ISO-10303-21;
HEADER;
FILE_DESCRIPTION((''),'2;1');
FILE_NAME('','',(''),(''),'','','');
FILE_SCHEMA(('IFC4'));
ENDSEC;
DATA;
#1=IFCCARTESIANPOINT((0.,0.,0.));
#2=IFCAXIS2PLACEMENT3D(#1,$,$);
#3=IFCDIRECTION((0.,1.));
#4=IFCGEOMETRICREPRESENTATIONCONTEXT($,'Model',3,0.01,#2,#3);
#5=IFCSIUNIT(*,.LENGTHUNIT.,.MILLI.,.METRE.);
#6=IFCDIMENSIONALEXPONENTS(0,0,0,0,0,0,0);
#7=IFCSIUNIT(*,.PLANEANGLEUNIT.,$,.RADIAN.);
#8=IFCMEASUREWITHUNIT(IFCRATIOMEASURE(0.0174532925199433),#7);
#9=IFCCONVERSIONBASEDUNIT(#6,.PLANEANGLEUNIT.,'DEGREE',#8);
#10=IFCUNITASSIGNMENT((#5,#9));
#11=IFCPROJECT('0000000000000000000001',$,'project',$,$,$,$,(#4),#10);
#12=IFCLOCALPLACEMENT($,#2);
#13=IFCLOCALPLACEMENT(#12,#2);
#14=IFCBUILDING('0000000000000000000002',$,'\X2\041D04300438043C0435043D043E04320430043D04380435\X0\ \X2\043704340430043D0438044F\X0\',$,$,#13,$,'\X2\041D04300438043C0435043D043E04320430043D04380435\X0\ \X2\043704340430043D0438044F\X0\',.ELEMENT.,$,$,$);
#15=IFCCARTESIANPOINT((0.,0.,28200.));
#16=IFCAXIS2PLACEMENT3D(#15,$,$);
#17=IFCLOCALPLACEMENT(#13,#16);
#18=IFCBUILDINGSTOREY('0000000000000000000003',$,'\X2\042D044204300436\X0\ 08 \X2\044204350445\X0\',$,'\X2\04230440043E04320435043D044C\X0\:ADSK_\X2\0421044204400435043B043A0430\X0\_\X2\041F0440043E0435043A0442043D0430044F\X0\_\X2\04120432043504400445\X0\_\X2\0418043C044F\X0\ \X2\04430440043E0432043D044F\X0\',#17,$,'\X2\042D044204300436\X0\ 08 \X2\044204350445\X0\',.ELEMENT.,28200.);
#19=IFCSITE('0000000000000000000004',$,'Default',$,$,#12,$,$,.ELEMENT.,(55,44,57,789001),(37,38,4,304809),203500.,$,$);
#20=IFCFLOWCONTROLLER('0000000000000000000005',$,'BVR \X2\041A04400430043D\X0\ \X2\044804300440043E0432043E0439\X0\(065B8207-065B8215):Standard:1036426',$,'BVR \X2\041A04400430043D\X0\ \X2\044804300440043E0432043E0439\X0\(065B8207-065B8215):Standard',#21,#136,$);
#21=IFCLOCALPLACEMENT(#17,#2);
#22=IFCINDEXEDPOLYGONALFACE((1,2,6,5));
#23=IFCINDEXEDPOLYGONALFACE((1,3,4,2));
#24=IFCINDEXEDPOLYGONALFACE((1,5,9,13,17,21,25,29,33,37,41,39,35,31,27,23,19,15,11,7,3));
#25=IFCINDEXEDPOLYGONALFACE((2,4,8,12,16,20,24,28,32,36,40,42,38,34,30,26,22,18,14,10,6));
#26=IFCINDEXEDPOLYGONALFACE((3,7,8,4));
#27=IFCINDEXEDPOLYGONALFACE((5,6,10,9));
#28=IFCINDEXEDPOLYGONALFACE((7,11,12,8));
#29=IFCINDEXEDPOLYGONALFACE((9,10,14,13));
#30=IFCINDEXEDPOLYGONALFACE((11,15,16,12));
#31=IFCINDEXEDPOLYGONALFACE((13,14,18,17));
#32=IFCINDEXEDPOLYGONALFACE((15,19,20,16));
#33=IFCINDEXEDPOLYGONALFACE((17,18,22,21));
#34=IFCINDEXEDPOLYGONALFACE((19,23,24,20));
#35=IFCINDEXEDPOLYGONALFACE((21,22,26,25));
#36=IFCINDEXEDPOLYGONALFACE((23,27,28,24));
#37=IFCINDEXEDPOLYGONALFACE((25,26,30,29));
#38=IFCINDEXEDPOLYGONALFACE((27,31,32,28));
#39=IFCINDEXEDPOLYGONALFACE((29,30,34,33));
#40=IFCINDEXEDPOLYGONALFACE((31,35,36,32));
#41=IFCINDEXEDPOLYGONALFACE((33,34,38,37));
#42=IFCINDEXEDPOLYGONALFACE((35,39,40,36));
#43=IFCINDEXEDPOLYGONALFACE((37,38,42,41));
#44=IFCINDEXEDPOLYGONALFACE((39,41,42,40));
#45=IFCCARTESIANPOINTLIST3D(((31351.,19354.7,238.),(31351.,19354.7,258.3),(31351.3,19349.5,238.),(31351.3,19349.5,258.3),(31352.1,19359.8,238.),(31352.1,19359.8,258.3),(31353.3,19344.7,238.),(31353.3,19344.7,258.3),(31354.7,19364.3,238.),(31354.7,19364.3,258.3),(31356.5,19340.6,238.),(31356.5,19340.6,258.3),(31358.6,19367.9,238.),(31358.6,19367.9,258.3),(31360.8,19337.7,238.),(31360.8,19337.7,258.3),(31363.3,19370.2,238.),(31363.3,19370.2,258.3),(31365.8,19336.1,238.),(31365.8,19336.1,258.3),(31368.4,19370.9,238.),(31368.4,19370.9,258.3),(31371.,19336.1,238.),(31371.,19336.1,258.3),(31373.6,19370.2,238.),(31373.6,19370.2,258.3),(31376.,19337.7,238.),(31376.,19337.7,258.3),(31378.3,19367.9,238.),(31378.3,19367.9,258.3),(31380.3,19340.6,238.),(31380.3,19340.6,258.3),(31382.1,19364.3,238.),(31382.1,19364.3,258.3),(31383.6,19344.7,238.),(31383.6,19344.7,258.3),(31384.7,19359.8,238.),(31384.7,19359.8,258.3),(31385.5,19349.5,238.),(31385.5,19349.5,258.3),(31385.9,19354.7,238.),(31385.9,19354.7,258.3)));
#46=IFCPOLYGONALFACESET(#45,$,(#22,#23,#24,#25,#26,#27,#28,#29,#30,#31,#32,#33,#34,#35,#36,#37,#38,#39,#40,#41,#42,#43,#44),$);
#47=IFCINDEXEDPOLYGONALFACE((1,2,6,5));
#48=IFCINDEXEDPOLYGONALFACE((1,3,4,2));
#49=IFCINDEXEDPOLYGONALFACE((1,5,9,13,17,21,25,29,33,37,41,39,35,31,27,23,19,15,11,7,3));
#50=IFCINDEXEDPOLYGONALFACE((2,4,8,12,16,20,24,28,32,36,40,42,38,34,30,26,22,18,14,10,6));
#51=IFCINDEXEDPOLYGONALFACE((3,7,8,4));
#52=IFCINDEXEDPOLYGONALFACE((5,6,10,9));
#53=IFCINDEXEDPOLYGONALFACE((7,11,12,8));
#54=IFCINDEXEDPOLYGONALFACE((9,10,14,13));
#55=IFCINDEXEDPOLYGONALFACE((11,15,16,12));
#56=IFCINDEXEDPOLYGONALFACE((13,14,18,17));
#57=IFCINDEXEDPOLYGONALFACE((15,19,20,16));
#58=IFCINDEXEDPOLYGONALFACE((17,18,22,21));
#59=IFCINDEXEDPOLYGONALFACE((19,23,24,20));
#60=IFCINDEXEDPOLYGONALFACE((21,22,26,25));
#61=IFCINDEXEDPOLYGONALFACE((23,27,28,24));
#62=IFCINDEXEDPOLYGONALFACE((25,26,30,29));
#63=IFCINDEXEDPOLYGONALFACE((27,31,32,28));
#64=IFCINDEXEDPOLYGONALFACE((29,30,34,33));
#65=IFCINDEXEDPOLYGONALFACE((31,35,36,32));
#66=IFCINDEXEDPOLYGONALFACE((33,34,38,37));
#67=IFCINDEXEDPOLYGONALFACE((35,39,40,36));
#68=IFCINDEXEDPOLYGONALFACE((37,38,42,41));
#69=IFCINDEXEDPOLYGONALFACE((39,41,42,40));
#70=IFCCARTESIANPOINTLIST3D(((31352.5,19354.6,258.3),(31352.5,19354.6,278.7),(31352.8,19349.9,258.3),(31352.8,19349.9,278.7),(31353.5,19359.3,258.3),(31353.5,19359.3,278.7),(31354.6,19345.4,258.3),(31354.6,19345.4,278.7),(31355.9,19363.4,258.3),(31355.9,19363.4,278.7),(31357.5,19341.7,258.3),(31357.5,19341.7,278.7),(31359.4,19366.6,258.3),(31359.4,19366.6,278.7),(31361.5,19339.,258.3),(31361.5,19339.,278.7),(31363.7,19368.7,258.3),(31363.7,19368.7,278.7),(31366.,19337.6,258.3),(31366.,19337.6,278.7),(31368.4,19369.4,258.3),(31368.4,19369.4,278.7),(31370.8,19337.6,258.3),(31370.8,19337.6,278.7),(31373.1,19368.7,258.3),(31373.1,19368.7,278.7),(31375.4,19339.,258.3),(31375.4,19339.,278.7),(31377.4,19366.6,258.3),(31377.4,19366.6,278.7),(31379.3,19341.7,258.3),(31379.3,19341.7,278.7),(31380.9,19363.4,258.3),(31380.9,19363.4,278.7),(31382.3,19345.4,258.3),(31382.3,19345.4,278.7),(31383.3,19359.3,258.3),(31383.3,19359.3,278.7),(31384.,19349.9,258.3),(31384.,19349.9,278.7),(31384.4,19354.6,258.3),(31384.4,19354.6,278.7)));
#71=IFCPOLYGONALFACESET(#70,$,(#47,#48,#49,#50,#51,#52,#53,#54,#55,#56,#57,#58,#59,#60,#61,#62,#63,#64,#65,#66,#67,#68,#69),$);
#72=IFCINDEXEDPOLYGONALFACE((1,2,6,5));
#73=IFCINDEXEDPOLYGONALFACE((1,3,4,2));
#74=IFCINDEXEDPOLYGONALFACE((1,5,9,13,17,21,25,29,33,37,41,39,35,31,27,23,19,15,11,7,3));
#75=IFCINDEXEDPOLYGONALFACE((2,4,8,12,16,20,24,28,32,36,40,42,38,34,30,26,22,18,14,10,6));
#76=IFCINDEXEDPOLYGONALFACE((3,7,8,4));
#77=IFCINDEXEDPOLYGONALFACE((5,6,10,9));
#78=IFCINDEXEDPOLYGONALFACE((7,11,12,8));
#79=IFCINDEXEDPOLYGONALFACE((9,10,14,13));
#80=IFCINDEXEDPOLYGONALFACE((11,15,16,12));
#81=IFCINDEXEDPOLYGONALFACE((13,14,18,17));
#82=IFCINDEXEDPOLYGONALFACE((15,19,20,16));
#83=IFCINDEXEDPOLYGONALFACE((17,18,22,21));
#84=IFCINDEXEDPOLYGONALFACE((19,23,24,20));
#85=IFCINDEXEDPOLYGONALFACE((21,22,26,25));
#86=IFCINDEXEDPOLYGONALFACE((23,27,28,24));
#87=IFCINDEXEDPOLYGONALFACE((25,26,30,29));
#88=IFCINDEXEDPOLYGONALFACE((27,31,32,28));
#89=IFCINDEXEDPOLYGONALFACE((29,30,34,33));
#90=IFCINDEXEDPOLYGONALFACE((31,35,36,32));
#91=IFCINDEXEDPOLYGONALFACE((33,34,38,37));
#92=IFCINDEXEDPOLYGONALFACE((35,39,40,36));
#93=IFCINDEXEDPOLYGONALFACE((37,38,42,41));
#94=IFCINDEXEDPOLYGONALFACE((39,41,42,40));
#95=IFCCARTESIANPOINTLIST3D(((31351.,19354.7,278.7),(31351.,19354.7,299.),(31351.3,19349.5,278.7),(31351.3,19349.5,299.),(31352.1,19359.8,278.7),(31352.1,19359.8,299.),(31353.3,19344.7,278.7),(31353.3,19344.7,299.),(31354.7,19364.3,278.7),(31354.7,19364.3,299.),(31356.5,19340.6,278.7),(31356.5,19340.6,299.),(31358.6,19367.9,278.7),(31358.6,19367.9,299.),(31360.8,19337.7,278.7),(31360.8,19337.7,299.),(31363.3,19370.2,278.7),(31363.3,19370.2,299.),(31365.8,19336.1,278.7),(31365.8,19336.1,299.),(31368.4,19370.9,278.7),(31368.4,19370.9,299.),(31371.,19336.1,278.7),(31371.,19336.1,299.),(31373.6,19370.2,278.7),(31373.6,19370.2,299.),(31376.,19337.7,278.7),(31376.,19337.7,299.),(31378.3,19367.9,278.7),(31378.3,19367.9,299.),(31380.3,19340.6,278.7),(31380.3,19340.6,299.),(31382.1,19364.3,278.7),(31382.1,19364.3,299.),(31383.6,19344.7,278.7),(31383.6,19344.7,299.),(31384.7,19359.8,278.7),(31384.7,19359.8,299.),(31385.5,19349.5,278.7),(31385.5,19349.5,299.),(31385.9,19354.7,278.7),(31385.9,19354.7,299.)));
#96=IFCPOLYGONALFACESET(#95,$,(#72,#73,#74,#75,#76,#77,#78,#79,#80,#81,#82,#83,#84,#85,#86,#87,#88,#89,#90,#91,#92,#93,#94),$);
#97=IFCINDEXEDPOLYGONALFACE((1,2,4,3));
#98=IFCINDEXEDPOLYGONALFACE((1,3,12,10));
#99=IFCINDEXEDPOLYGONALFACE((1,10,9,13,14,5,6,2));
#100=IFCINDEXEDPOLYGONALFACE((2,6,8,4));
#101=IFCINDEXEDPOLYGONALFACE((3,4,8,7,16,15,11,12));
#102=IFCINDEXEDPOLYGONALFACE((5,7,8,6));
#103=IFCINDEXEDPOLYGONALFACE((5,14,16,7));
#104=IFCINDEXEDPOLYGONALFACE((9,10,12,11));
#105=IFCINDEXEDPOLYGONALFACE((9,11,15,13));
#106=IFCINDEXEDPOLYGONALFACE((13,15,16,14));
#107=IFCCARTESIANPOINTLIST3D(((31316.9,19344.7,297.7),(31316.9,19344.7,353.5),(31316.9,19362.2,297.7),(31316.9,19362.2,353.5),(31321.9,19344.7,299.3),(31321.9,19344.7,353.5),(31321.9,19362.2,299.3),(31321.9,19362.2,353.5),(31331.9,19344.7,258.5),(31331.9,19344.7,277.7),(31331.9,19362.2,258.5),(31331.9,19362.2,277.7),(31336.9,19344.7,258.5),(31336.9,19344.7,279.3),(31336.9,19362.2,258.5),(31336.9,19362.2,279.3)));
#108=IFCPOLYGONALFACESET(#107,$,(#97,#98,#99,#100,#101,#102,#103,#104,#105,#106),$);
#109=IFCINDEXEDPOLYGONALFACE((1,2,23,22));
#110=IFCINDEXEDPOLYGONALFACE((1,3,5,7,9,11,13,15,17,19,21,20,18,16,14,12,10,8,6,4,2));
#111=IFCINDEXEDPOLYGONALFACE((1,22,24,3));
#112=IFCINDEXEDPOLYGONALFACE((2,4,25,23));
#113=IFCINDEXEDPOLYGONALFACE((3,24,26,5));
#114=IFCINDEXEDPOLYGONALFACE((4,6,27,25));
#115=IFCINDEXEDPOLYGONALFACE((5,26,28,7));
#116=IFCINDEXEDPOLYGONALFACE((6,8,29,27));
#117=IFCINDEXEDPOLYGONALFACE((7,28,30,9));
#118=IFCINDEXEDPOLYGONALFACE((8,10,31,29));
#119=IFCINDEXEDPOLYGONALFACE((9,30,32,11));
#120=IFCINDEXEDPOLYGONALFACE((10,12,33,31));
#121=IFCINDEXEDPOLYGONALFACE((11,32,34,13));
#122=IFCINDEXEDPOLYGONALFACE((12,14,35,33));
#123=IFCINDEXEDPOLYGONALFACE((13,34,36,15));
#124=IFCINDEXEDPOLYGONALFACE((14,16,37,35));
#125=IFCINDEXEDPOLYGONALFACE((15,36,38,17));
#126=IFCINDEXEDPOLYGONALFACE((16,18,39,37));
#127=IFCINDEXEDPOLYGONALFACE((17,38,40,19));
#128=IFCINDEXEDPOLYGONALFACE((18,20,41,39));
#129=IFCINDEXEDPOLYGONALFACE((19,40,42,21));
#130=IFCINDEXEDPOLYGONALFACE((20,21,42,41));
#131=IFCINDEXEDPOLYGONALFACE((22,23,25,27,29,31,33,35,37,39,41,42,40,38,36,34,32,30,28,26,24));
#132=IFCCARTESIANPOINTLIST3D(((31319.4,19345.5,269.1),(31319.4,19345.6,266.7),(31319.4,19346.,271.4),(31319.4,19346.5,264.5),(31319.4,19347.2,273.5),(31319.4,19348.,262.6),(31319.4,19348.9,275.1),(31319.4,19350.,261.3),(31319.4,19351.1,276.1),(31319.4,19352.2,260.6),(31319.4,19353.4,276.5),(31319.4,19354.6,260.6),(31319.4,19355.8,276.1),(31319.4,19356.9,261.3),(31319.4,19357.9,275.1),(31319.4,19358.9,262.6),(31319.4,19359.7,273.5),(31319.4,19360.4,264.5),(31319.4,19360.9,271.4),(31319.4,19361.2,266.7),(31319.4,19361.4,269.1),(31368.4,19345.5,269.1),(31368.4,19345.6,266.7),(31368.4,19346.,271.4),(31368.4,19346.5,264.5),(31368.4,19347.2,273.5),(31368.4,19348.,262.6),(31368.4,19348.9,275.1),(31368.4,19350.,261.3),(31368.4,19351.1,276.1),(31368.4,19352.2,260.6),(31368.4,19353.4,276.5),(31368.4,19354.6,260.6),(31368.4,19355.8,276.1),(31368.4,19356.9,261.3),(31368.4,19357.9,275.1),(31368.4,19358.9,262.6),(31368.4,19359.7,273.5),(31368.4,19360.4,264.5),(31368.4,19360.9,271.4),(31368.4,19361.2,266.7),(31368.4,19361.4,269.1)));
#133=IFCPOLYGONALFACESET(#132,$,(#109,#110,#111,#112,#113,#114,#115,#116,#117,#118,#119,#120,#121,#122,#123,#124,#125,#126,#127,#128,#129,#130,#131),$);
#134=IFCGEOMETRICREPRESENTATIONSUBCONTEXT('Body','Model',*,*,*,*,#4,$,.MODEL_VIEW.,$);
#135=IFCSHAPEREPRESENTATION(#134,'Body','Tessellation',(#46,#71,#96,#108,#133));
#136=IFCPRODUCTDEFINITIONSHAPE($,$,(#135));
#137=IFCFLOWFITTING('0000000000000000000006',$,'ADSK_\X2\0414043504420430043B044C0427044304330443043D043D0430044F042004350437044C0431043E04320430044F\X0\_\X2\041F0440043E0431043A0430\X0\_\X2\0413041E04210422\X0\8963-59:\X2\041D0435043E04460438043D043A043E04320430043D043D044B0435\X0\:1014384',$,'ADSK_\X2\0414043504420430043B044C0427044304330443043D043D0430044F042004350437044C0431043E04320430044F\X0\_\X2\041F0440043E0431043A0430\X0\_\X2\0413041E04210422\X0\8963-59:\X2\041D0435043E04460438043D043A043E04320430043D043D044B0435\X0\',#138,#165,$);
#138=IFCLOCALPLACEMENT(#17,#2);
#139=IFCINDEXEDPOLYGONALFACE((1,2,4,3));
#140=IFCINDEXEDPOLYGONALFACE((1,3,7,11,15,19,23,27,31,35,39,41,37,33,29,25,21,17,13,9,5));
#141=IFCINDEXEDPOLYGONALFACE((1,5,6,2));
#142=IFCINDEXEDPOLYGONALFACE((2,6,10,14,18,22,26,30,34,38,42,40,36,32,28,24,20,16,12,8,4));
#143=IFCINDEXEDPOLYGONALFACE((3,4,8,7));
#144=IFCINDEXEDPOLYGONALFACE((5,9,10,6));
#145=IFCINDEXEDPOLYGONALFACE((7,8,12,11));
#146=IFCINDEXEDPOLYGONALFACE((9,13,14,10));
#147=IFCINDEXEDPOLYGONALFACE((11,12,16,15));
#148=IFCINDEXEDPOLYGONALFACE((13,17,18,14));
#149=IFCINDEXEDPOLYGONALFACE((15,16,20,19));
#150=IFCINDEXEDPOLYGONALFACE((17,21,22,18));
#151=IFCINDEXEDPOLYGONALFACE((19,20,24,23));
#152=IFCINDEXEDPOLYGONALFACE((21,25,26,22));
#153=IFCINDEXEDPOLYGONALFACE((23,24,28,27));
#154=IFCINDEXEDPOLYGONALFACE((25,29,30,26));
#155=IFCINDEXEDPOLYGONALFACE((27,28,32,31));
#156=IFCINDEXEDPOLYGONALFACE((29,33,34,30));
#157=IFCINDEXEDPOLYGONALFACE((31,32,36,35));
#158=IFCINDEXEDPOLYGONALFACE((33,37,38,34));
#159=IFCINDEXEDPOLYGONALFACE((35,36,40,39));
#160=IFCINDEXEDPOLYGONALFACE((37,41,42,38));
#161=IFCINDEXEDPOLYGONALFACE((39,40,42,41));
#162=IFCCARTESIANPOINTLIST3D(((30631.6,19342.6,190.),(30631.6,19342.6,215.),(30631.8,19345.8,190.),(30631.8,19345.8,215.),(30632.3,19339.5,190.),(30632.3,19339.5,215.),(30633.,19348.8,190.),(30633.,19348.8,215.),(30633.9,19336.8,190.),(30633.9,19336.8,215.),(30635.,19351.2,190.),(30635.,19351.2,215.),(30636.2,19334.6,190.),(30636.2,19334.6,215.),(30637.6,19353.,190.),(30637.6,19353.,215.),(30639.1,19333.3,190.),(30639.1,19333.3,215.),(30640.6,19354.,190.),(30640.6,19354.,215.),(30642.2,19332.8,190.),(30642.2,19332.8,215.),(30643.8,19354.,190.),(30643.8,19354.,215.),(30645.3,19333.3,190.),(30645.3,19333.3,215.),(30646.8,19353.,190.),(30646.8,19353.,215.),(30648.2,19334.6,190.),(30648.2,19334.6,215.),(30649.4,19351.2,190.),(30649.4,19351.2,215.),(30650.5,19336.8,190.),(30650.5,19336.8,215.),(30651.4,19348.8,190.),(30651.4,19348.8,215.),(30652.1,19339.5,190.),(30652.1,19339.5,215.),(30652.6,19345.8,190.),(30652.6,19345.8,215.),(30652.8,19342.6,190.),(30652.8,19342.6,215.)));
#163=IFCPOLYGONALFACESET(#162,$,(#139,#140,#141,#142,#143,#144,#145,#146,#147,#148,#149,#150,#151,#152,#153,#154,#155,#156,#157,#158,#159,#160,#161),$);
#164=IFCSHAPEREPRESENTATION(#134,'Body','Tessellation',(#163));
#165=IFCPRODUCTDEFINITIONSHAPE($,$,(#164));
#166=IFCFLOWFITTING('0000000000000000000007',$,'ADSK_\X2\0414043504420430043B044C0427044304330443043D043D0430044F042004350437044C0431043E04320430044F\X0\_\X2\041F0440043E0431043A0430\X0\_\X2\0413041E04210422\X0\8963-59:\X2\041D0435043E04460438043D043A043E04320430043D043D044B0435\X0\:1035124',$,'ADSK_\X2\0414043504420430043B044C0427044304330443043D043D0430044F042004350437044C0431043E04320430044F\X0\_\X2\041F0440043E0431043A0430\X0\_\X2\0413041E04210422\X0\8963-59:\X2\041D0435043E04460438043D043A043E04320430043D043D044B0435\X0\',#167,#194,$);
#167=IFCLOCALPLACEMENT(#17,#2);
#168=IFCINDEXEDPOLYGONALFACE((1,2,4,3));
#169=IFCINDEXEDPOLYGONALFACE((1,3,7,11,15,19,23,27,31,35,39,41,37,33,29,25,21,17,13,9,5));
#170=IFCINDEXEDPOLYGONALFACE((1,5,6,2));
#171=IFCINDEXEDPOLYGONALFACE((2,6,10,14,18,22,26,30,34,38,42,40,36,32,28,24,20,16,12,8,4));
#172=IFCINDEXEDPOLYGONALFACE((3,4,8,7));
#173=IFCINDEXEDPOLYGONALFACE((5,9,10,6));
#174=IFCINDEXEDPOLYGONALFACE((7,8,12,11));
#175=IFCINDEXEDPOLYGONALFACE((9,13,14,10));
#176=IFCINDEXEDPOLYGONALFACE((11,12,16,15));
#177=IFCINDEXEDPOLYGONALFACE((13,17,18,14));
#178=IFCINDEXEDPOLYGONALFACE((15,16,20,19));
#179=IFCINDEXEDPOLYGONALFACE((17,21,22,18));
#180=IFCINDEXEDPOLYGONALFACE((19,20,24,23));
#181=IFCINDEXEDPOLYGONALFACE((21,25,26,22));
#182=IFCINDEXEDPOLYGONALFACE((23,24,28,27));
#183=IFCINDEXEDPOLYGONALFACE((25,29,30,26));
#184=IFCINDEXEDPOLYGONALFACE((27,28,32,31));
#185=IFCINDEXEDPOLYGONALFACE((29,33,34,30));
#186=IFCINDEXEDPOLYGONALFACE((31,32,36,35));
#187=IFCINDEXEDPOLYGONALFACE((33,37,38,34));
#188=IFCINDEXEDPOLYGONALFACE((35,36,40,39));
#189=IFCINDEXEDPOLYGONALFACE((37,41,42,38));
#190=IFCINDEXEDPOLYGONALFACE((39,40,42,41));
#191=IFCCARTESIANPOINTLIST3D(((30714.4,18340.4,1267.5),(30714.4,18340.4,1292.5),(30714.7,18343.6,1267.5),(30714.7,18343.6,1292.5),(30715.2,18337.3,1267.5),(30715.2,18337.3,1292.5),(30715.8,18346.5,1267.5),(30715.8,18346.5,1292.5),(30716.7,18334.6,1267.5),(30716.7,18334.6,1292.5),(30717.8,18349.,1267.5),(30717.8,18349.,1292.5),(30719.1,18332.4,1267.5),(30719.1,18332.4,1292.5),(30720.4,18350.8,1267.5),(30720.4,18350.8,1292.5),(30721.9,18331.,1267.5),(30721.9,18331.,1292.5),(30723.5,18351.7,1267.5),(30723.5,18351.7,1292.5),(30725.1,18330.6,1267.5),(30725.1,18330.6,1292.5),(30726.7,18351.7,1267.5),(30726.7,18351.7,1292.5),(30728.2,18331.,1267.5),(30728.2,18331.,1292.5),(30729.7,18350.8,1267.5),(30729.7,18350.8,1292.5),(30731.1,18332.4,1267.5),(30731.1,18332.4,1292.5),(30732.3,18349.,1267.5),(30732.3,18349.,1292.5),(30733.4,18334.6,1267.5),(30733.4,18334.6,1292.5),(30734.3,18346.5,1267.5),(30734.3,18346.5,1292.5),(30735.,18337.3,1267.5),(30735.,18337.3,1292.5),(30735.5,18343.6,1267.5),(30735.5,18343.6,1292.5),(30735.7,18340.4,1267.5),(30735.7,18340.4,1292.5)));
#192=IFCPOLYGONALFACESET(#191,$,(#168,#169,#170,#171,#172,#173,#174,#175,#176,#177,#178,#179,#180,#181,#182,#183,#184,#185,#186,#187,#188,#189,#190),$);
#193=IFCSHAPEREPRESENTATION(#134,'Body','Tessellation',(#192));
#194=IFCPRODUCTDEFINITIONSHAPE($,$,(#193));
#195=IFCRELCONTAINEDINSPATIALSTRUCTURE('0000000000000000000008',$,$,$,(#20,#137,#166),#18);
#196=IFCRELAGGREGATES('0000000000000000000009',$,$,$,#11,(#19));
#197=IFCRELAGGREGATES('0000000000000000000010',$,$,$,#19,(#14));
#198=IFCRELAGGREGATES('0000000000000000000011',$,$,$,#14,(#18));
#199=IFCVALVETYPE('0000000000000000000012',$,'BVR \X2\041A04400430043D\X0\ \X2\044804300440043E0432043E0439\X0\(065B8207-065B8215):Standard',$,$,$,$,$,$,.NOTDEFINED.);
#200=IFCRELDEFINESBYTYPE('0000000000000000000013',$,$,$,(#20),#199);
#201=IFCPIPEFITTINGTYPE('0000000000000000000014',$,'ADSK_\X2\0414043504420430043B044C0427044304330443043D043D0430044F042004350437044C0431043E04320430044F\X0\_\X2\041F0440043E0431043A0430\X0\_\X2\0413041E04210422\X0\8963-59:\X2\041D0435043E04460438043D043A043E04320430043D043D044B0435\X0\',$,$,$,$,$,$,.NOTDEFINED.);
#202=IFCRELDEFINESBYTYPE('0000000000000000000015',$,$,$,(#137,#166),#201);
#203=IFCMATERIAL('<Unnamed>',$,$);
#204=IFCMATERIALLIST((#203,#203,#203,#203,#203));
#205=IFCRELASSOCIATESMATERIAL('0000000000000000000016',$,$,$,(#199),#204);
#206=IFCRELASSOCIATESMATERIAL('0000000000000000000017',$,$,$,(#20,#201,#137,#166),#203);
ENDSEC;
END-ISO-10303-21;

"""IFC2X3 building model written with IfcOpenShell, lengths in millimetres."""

from ifc_helpers import new_model, entity, si_unit, converted_unit, direction, frame, origin, origin_2d_with_axis, place, context, subcontext, project, spatial, polyline, circle, outline, extrude, source, transform, mapped, material, material_list, type_object, type_shapes, element, save


model = new_model("IFC2X3")

# Units and contexts
model_context = context("Model", 3, precision=0.01, world=origin(), true_north=direction((0.0, 1.0)))
body_context = subcontext(model_context, "Body", "Model", "MODEL_VIEW")
ifc_project = project(units=[si_unit("LENGTHUNIT", "METRE", prefix="MILLI"), converted_unit("PLANEANGLEUNIT", "DEGREE", entity("IfcRatioMeasure", 0.0174532925199433), si_unit("PLANEANGLEUNIT", "RADIAN"), dimensions=[0, 0, 0, 0, 0, 0, 0])], contexts=[model_context])

# Site, building, storey
site_placement = place(None, origin())
site = spatial("IfcSite", under=ifc_project, at=site_placement, Name="Default", CompositionType="ELEMENT", RefLatitude=(55, 44, 57, 789001), RefLongitude=(37, 38, 4, 304809), RefElevation=203500.0)
building_placement = place(site_placement, origin())
building = spatial("IfcBuilding", under=site, at=building_placement, Name="Наименование здания", LongName="Наименование здания", CompositionType="ELEMENT")
storey_placement = place(building_placement, frame((0.0, 0.0, 28200.0)))
storey = spatial("IfcBuildingStorey", under=building, at=storey_placement, Name="Этаж 08 тех", ObjectType="Уровень:ADSK_Стрелка_Проектная_Вверх_Имя уровня", LongName="Этаж 08 тех", CompositionType="ELEMENT", Elevation=28200.0)

# Flow controller
ifc_material = material(Name="<Unnamed>")
ifc_material_list = material_list([ifc_material, ifc_material, ifc_material, ifc_material, ifc_material])
valve_type = type_object("IfcValveType", Name="BVR Кран шаровой(065B8207-065B8215):Standard", PredefinedType="NOTDEFINED", material=ifc_material_list)
shared_shape_1 = source(origin(), body_context, "Body", "SweptSolid", [
    extrude(circle(Radius=17.5, at=origin_2d_with_axis()), frame((-30.5, 0.0, 0.0), z_axis=(1.0, 0.0, 0.0), x_axis=(0.0, 1.0, 0.0)), (0.0, 0.0, 1.0), 20.3),
    extrude(circle(Radius=16.0, at=origin_2d_with_axis()), frame((-10.2, 0.0, 0.0), z_axis=(1.0, 0.0, 0.0), x_axis=(0.0, 1.0, 0.0)), (0.0, 0.0, 1.0), 20.3),
    extrude(circle(Radius=17.5, at=origin_2d_with_axis()), frame((10.2, 0.0, 0.0), z_axis=(1.0, 0.0, 0.0), x_axis=(0.0, 1.0, 0.0)), (0.0, 0.0, 1.0), 20.3),
    extrude(outline(polyline([(-38.8, -5.0), (-38.8, -10.0), (-17.9, -10.0), (2.1, 5.0), (56.2, 5.0), (56.2, 10.0), (0.4, 10.0), (-19.6, -5.0), (-38.8, -5.0)])), frame((28.8, -8.8, 41.5), z_axis=(0.0, -1.0, 0.0), x_axis=(1.0, 0.0, 0.0)), (0.0, 0.0, -1.0), 17.5),
    extrude(circle(Radius=8.0, at=origin_2d_with_axis()), origin(), (0.0, 0.0, 1.0), 49.0),
])
type_shapes(valve_type, [shared_shape_1])
for number, where, z_axis, x_axis, name in (
    (1, (31368.4, 19353.4, 268.5), (-1.0, 0.0, 0.0), (0.0, 0.0, 1.0), "BVR Кран шаровой(065B8207-065B8215):Standard:1036426"),
):
    element("IfcFlowController", number, at=place(storey_placement, frame(where, z_axis=z_axis, x_axis=x_axis)), inside=storey, type_object=valve_type, material=ifc_material, Name=name, ObjectType="BVR Кран шаровой(065B8207-065B8215):Standard", context=body_context, shape_type="MappedRepresentation", body=[
        mapped(shared_shape_1, transform((0.0, 0.0, 0.0), scale=1.0)),
    ])

# Flow fittings
pipe_fitting_type_1 = type_object("IfcPipeFittingType", Name="ADSK_ДетальЧугуннаяРезьбовая_Пробка_ГОСТ8963-59:Неоцинкованные", PredefinedType="NOTDEFINED", material=ifc_material)
shared_shape_2 = source(origin(), body_context, "Body", "SweptSolid", [
    extrude(circle(Radius=10.7, at=origin_2d_with_axis()), frame((0.0, 0.0, 0.0), z_axis=(1.0, 0.0, 0.0), x_axis=(0.0, 1.0, 0.0)), (0.0, 0.0, 1.0), 25.0),
])
type_shapes(pipe_fitting_type_1, [shared_shape_2])
for number, where, z_axis, x_axis, name in (
    (2, (30642.2, 19343.4, 215.0), (-1.0, 0.0, 0.0), (0.0, 0.0, -1.0), "ADSK_ДетальЧугуннаяРезьбовая_Пробка_ГОСТ8963-59:Неоцинкованные:1014384"),
    (3, (30725.1, 18341.2, 1292.5), (-1.0, 0.0, 0.0), (0.0, 0.0, -1.0), "ADSK_ДетальЧугуннаяРезьбовая_Пробка_ГОСТ8963-59:Неоцинкованные:1035124"),
):
    element("IfcFlowFitting", number, at=place(storey_placement, frame(where, z_axis=z_axis, x_axis=x_axis)), inside=storey, type_object=pipe_fitting_type_1, material=ifc_material, Name=name, ObjectType="ADSK_ДетальЧугуннаяРезьбовая_Пробка_ГОСТ8963-59:Неоцинкованные", context=body_context, shape_type="MappedRepresentation", body=[
        mapped(shared_shape_2, transform((0.0, 0.0, 0.0), scale=1.0)),
    ])

save(model, "model.ifc")
